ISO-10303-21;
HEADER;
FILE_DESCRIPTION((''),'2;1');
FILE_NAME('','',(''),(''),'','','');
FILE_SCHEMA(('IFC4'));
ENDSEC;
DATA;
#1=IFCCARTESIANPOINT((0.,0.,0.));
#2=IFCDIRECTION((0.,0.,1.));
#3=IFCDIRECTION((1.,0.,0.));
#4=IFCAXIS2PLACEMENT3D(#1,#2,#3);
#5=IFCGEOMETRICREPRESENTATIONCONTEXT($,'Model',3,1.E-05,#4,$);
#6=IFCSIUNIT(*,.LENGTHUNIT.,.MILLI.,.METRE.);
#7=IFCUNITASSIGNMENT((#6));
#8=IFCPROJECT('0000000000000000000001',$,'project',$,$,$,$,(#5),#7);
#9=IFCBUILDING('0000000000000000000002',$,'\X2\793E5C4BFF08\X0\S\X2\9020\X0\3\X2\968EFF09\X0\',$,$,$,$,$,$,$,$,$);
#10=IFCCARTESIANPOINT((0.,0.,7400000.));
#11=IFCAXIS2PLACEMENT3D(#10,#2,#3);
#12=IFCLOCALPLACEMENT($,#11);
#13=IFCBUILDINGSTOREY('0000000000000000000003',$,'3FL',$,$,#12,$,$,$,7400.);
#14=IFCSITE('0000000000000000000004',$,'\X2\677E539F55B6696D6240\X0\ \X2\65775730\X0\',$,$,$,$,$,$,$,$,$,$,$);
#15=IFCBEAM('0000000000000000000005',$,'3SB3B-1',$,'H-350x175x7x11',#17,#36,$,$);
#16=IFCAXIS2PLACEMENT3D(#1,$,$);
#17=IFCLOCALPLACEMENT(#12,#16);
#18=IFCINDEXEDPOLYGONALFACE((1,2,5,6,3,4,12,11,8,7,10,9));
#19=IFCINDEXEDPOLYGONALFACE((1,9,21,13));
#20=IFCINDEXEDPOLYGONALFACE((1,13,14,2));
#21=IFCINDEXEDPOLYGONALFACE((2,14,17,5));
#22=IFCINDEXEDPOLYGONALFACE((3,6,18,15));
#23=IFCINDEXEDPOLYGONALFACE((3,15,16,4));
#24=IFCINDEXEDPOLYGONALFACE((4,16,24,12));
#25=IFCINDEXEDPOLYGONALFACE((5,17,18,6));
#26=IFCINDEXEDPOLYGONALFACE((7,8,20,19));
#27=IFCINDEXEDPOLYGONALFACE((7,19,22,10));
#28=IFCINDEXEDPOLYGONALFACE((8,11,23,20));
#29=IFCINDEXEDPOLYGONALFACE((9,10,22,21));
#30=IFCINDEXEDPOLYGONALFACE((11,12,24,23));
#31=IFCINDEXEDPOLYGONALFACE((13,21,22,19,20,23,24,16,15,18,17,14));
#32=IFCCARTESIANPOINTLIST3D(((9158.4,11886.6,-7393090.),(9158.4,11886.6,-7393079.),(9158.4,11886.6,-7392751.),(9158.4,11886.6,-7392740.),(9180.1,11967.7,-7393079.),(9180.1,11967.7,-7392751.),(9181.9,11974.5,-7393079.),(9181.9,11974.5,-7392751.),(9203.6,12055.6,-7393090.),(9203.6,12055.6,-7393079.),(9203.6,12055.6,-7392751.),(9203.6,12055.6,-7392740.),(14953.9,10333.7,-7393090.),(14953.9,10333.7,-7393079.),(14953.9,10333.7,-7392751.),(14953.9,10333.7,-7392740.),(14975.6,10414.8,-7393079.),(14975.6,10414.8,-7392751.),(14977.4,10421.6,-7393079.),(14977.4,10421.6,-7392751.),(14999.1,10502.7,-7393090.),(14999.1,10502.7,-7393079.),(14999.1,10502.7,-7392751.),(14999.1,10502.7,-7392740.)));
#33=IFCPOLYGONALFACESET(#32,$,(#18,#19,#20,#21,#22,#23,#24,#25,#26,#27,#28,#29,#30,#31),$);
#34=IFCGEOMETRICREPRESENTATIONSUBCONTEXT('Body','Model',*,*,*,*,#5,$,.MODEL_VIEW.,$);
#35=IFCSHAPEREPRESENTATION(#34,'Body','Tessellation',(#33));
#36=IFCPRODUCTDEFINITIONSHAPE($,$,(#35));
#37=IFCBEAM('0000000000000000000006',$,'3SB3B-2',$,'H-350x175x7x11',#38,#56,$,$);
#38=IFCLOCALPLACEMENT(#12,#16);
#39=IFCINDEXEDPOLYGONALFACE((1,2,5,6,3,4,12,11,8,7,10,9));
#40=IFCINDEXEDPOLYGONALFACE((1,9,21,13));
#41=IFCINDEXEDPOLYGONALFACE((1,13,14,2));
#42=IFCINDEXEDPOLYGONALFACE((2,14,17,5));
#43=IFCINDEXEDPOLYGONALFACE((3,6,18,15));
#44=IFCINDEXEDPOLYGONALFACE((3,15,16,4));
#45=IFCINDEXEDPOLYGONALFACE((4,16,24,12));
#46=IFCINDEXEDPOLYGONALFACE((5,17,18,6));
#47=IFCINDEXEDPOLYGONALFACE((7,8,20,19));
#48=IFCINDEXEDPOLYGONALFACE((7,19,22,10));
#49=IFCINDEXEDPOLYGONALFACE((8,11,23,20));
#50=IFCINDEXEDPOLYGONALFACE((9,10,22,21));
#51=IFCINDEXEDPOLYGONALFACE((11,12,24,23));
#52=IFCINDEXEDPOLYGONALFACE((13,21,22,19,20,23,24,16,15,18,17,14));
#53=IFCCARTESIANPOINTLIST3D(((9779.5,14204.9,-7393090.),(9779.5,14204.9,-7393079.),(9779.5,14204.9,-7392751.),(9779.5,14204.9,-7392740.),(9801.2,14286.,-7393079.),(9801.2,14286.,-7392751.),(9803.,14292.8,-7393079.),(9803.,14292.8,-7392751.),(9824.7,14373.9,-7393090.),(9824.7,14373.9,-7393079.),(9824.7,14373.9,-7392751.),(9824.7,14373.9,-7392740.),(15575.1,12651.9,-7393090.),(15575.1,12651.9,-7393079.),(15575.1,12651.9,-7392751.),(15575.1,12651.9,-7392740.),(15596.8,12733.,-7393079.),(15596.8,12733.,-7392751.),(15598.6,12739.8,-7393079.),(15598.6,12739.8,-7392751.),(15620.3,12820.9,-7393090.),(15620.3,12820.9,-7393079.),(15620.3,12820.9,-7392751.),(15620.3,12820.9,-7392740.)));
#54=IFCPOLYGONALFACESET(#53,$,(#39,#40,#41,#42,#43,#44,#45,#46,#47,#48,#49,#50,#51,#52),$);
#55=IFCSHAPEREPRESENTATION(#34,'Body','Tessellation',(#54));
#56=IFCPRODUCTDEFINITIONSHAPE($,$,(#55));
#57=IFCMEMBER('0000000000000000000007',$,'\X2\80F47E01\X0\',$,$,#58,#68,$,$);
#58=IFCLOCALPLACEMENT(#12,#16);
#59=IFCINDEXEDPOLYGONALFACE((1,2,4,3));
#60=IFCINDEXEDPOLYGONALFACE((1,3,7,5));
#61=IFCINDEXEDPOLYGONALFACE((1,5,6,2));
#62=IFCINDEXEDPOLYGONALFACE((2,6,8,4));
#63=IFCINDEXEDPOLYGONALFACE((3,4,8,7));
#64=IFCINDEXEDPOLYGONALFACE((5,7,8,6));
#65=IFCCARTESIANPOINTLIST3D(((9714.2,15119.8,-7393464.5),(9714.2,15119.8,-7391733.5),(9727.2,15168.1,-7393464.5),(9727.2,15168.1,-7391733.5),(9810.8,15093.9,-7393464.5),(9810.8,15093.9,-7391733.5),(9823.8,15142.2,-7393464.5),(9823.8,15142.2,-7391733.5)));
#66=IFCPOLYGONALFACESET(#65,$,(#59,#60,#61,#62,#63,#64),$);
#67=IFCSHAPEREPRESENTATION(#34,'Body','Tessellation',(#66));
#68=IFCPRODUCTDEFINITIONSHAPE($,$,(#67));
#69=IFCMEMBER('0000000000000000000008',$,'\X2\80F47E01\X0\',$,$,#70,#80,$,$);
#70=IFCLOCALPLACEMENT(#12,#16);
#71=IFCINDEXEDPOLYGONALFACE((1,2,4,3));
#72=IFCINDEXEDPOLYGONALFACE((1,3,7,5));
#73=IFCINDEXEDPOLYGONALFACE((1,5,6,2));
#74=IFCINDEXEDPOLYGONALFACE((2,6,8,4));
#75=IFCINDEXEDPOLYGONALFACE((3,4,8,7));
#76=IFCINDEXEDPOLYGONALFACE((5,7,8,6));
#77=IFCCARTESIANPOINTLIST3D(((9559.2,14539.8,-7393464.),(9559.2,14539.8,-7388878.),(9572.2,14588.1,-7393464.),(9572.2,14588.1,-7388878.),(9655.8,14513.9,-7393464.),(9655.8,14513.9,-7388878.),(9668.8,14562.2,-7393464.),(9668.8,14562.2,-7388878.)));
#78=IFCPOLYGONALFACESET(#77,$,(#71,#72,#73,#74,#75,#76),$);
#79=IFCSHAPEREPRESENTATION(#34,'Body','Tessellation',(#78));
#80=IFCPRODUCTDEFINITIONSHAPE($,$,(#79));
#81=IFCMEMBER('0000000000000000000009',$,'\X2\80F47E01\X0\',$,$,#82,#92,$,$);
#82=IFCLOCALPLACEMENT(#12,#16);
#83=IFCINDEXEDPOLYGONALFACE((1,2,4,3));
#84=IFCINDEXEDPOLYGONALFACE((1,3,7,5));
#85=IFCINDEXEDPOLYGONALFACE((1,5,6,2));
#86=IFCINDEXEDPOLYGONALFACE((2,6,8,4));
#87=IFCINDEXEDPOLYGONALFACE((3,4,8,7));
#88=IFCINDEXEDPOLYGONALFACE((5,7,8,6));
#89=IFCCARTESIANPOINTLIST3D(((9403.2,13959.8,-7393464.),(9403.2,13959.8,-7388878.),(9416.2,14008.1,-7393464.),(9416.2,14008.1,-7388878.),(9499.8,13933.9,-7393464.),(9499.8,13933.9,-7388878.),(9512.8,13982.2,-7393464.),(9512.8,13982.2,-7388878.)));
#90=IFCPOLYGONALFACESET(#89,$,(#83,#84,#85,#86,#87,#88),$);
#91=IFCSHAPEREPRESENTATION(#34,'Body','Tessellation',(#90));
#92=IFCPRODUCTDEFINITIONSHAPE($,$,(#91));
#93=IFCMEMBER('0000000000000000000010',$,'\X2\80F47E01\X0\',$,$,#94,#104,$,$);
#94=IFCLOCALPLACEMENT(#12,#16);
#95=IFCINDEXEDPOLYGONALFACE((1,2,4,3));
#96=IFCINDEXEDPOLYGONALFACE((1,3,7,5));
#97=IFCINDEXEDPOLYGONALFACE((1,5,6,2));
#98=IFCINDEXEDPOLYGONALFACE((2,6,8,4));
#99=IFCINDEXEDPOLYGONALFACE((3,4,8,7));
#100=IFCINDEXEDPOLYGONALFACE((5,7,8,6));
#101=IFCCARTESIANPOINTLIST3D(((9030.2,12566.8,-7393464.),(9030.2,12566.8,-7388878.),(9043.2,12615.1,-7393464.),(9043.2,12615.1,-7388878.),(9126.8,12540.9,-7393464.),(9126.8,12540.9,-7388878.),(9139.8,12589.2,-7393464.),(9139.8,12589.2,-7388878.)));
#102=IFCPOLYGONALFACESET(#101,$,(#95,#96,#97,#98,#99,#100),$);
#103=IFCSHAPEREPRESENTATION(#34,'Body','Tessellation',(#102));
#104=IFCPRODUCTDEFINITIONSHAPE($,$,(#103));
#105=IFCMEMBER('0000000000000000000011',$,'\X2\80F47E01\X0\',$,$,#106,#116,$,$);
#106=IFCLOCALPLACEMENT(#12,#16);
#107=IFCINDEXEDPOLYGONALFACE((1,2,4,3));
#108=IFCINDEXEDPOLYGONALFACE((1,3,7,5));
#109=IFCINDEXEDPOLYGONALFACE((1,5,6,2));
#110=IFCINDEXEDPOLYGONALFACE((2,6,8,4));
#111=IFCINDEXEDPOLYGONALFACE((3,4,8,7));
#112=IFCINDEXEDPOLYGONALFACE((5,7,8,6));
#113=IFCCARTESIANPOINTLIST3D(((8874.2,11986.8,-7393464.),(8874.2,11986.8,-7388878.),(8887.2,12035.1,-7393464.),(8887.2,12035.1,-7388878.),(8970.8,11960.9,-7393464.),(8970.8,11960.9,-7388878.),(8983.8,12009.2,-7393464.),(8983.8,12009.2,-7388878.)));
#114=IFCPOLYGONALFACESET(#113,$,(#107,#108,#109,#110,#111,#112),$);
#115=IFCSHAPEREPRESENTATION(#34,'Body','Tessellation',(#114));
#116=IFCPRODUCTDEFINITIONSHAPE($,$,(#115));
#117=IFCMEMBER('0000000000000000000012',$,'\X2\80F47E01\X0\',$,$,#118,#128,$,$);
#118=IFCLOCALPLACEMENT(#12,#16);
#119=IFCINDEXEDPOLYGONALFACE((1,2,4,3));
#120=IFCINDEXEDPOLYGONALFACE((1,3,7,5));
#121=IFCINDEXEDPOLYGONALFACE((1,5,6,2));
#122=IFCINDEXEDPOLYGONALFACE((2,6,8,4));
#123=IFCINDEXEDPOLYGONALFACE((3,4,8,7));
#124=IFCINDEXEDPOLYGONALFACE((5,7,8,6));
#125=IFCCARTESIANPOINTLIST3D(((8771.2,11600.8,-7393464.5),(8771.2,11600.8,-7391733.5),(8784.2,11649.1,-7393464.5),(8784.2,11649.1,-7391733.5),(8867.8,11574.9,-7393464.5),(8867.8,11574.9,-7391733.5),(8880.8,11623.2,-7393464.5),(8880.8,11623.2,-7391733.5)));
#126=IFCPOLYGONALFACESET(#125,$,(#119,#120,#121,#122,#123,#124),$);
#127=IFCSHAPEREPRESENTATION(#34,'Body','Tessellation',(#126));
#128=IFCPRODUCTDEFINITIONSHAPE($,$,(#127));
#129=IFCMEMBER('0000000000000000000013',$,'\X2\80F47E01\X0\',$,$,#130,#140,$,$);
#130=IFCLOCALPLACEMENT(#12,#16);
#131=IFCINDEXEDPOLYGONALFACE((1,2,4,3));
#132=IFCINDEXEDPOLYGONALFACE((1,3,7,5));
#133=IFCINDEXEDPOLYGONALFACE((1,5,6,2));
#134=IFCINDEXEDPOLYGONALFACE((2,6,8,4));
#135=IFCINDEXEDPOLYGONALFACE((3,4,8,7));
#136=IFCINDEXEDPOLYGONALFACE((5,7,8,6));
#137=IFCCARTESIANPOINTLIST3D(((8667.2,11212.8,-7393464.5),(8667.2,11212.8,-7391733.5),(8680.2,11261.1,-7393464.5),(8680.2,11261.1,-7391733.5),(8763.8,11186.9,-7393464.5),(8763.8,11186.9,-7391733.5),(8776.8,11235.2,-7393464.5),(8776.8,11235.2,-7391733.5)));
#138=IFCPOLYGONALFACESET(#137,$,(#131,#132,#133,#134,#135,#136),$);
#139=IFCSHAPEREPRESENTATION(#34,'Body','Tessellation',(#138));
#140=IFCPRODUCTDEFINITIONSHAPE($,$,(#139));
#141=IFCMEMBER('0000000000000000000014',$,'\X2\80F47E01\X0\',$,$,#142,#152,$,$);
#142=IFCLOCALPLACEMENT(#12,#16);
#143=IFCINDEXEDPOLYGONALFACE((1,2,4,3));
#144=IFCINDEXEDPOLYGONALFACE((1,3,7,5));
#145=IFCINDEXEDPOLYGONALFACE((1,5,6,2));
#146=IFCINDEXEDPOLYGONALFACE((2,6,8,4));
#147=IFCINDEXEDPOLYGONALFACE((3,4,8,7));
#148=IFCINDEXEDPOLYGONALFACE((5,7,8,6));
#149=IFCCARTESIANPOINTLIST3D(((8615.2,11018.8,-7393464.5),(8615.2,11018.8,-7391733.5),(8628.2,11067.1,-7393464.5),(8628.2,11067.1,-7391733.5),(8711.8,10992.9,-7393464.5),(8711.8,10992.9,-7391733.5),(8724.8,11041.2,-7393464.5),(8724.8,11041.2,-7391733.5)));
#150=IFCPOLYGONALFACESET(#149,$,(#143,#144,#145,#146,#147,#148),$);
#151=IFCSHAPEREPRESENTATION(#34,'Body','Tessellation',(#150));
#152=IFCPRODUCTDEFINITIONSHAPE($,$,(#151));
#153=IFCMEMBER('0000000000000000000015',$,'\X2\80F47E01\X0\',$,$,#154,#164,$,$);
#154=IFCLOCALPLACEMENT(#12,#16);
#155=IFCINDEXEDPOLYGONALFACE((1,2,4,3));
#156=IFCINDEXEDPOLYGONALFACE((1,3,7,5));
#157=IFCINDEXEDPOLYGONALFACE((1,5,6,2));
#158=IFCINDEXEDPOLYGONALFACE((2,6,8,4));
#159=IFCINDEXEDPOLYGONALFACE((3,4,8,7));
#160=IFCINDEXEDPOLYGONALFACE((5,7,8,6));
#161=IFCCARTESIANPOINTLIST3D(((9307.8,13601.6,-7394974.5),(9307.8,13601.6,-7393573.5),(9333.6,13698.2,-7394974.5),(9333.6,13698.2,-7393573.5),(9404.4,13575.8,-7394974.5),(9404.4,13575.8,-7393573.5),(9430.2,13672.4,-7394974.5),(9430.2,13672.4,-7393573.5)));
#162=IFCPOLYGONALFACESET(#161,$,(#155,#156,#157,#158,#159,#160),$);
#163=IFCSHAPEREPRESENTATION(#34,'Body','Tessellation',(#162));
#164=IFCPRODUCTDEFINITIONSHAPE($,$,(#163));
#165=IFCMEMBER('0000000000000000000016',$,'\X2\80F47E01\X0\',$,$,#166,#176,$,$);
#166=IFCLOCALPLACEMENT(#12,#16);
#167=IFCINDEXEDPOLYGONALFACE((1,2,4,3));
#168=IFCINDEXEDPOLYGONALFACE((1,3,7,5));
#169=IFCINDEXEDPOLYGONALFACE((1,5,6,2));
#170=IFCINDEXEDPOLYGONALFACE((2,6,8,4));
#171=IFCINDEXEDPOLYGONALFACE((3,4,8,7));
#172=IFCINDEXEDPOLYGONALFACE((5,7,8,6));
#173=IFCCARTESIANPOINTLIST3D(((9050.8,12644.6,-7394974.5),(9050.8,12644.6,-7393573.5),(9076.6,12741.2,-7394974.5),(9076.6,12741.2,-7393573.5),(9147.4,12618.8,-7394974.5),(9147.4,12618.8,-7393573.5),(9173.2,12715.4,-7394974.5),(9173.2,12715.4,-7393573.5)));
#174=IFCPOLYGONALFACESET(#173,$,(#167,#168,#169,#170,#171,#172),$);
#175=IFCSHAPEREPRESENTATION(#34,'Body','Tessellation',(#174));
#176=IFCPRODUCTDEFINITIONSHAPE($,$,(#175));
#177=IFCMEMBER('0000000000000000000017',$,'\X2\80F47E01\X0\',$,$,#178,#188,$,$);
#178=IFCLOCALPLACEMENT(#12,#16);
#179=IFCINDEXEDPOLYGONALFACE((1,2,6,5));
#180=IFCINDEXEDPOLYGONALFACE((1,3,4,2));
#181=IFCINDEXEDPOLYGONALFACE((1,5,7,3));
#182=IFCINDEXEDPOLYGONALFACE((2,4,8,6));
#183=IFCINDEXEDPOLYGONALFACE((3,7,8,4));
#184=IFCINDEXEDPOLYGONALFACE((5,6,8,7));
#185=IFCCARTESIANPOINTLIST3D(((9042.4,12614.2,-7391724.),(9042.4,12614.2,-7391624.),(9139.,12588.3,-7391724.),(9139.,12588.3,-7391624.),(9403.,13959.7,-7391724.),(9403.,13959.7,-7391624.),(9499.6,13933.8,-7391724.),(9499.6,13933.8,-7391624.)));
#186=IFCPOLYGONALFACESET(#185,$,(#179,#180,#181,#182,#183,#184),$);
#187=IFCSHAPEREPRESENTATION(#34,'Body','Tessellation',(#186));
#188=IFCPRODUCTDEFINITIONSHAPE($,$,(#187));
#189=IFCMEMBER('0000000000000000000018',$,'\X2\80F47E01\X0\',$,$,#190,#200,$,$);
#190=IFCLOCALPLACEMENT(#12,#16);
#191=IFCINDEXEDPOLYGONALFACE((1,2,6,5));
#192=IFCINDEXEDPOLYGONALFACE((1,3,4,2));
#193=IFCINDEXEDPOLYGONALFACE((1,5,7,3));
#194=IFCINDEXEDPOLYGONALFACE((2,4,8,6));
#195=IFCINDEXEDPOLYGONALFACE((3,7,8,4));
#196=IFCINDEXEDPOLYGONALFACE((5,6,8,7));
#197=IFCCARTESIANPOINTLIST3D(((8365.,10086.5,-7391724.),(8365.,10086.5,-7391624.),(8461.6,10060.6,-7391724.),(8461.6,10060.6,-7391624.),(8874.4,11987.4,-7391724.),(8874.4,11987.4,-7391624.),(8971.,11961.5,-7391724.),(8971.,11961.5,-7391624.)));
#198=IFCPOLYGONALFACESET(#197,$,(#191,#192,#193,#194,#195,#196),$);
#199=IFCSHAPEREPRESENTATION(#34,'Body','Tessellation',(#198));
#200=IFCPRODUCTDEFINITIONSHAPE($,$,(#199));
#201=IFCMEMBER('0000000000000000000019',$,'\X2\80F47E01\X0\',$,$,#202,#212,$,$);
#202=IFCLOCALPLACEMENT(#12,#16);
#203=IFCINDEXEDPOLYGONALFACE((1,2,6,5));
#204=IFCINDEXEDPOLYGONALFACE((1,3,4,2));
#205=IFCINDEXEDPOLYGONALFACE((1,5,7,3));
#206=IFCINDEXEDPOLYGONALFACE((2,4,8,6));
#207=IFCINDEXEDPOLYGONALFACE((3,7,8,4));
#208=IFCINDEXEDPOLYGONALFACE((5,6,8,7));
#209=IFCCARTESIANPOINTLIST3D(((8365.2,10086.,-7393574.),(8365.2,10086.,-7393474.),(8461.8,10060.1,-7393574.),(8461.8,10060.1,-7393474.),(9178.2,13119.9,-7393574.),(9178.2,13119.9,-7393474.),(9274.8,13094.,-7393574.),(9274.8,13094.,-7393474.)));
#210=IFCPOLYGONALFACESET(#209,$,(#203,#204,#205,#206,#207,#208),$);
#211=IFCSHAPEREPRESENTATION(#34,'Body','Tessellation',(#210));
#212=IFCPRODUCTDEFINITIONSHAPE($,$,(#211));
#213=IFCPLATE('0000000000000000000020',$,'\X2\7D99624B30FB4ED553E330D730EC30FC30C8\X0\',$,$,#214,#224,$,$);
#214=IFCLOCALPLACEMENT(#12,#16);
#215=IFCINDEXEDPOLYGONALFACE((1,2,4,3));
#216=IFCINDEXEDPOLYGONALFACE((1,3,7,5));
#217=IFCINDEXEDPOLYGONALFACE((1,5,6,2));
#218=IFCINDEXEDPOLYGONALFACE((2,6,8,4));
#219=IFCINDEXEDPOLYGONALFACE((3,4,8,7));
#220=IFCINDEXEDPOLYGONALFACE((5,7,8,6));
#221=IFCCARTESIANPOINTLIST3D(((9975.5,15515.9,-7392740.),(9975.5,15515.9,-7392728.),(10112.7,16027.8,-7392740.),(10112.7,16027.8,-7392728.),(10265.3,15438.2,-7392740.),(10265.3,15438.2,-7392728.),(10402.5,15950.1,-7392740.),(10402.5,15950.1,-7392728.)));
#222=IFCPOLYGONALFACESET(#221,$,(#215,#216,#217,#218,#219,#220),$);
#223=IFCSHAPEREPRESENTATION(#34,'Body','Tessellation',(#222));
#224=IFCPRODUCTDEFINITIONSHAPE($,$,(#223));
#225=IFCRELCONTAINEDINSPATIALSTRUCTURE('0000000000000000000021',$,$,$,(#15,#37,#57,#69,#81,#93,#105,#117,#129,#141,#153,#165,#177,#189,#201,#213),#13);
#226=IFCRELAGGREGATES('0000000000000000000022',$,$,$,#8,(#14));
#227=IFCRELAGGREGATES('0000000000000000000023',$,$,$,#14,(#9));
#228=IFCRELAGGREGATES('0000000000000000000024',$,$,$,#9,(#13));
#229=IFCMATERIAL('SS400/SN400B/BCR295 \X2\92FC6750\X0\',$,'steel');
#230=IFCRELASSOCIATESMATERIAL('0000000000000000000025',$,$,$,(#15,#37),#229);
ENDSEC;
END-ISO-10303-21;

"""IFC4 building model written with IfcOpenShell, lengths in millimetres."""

from ifc_helpers import new_model, si_unit, frame, origin, origin_with_axes, place, context, subcontext, project, spatial, rectangle, i_section, extrude, material, element, save


model = new_model("IFC4")

# Units and contexts
model_context = context("Model", 3, precision=1e-05, world=origin_with_axes())
body_context = subcontext(model_context, "Body", "Model", "MODEL_VIEW")
ifc_project = project(units=[si_unit("LENGTHUNIT", "METRE", prefix="MILLI")], contexts=[model_context])

# Site, building, storey
site = spatial("IfcSite", under=ifc_project, Name="松原営業所 敷地")
building = spatial("IfcBuilding", under=site, Name="社屋（S造3階）")
storey_placement = place(None, frame((0.0, 0.0, 7400000.0), z_axis=(0.0, 0.0, 1.0), x_axis=(1.0, 0.0, 0.0)))
storey = spatial("IfcBuildingStorey", under=building, at=storey_placement, Name="3FL", Elevation=7400.0)

# Beams
ifc_material = material(Name="SS400/SN400B/BCR295 鋼材", Category="steel")
beam_1_placement = place(storey_placement, frame((9181.0, 11971.1, -7392740.0), z_axis=(0.965926, -0.258819, 0.0), x_axis=(0.258819, 0.965926, 0.0)))
element("IfcBeam", 1, at=beam_1_placement, inside=storey, material=ifc_material, Name="3SB3B-1", ObjectType="H-350x175x7x11", context=body_context, shape_type="SweptSolid", body=[
    extrude(i_section(OverallWidth=175.0, OverallDepth=350.0, WebThickness=7.0, FlangeThickness=11.0), frame((0.0, -175.0, 0.0)), (0.0, 0.0, 1.0), 5999.9),
])
beam_2_placement = place(storey_placement, frame((9802.1, 14289.4, -7392740.0), z_axis=(0.965923, -0.25883, 0.0), x_axis=(0.25883, 0.965923, 0.0)))
element("IfcBeam", 2, at=beam_2_placement, inside=storey, material=ifc_material, Name="3SB3B-2", ObjectType="H-350x175x7x11", context=body_context, shape_type="SweptSolid", body=[
    extrude(i_section(OverallWidth=175.0, OverallDepth=350.0, WebThickness=7.0, FlangeThickness=11.0), frame((0.0, -175.0, 0.0)), (0.0, 0.0, 1.0), 6000.1),
])

# Members
member_1_placement = place(storey_placement, frame((9775.5, 15155.1, -7392599.0), z_axis=(-0.258819, -0.965926, 0.0), x_axis=(0.965926, -0.258819, 0.0)))
element("IfcMember", 3, at=member_1_placement, inside=storey, Name="胴縁", context=body_context, shape_type="SweptSolid", body=[
    extrude(rectangle(XDim=100.0, YDim=1731.0), origin(), (0.0, 0.0, 1.0), 50.0),
])
for number, where, z_axis, x_axis, name in (
    (4, (9620.5, 14575.1, -7391171.0), (-0.258819, -0.965926, 0.0), (0.965926, -0.258819, 0.0), "胴縁"),
    (5, (9464.5, 13995.1, -7391171.0), (-0.258819, -0.965926, 0.0), (0.965926, -0.258819, 0.0), "胴縁"),
    (6, (9091.5, 12602.1, -7391171.0), (-0.258819, -0.965926, 0.0), (0.965926, -0.258819, 0.0), "胴縁"),
    (7, (8935.5, 12022.1, -7391171.0), (-0.258819, -0.965926, 0.0), (0.965926, -0.258819, 0.0), "胴縁"),
):
    element("IfcMember", number, at=place(storey_placement, frame(where, z_axis=z_axis, x_axis=x_axis)), inside=storey, Name=name, context=body_context, shape_type="SweptSolid", body=[
        extrude(rectangle(XDim=100.0, YDim=4586.0), origin(), (0.0, 0.0, 1.0), 50.0),
    ])
for number, where, z_axis, x_axis, name in (
    (8, (8832.5, 11636.1, -7392599.0), (-0.258819, -0.965926, 0.0), (0.965926, -0.258819, 0.0), "胴縁"),
    (9, (8728.5, 11248.1, -7392599.0), (-0.258819, -0.965926, 0.0), (0.965926, -0.258819, 0.0), "胴縁"),
    (10, (8676.5, 11054.1, -7392599.0), (-0.258819, -0.965926, 0.0), (0.965926, -0.258819, 0.0), "胴縁"),
):
    element("IfcMember", number, at=place(storey_placement, frame(where, z_axis=z_axis, x_axis=x_axis)), inside=storey, Name=name, context=body_context, shape_type="SweptSolid", body=[
        extrude(rectangle(XDim=100.0, YDim=1731.0), origin(), (0.0, 0.0, 1.0), 50.0),
    ])
for number, where, z_axis, x_axis, name in (
    (11, (9381.9, 13685.3, -7394274.0), (-0.258819, -0.965926, 0.0), (0.965926, -0.258819, 0.0), "胴縁"),
    (12, (9124.9, 12728.3, -7394274.0), (-0.258819, -0.965926, 0.0), (0.965926, -0.258819, 0.0), "胴縁"),
):
    element("IfcMember", number, at=place(storey_placement, frame(where, z_axis=z_axis, x_axis=x_axis)), inside=storey, Name=name, context=body_context, shape_type="SweptSolid", body=[
        extrude(rectangle(XDim=100.0, YDim=1401.0), origin(), (0.0, 0.0, 1.0), 100.0),
    ])
member_2_placement = place(storey_placement, frame((9451.3, 13946.8, -7391674.0), z_axis=(-0.258819, -0.965926, 0.0), x_axis=(0.965926, -0.258819, 0.0)))
element("IfcMember", 13, at=member_2_placement, inside=storey, Name="胴縁", context=body_context, shape_type="SweptSolid", body=[
    extrude(rectangle(XDim=100.0, YDim=100.0), origin(), (0.0, 0.0, 1.0), 1393.0),
])
member_3_placement = place(storey_placement, frame((8922.7, 11974.5, -7391674.0), z_axis=(-0.258819, -0.965926, 0.0), x_axis=(0.965926, -0.258819, 0.0)))
element("IfcMember", 14, at=member_3_placement, inside=storey, Name="胴縁", context=body_context, shape_type="SweptSolid", body=[
    extrude(rectangle(XDim=100.0, YDim=100.0), origin(), (0.0, 0.0, 1.0), 1968.0),
])
member_4_placement = place(storey_placement, frame((9226.5, 13107.0, -7393524.0), z_axis=(-0.258819, -0.965926, 0.0), x_axis=(0.965926, -0.258819, 0.0)))
element("IfcMember", 15, at=member_4_placement, inside=storey, Name="胴縁", context=body_context, shape_type="SweptSolid", body=[
    extrude(rectangle(XDim=100.0, YDim=100.0), origin(), (0.0, 0.0, 1.0), 3141.0),
])

# Plate
plate_1_placement = place(storey_placement, frame((10120.4, 15477.0, -7392734.0), z_axis=(0.258819, 0.965926, 0.0), x_axis=(-0.965926, 0.258819, 0.0)))
element("IfcPlate", 16, at=plate_1_placement, inside=storey, Name="継手・仕口プレート", context=body_context, shape_type="SweptSolid", body=[
    extrude(rectangle(XDim=300.0, YDim=12.0), origin(), (0.0, 0.0, 1.0), 530.0),
])

save(model, "model.ifc")
